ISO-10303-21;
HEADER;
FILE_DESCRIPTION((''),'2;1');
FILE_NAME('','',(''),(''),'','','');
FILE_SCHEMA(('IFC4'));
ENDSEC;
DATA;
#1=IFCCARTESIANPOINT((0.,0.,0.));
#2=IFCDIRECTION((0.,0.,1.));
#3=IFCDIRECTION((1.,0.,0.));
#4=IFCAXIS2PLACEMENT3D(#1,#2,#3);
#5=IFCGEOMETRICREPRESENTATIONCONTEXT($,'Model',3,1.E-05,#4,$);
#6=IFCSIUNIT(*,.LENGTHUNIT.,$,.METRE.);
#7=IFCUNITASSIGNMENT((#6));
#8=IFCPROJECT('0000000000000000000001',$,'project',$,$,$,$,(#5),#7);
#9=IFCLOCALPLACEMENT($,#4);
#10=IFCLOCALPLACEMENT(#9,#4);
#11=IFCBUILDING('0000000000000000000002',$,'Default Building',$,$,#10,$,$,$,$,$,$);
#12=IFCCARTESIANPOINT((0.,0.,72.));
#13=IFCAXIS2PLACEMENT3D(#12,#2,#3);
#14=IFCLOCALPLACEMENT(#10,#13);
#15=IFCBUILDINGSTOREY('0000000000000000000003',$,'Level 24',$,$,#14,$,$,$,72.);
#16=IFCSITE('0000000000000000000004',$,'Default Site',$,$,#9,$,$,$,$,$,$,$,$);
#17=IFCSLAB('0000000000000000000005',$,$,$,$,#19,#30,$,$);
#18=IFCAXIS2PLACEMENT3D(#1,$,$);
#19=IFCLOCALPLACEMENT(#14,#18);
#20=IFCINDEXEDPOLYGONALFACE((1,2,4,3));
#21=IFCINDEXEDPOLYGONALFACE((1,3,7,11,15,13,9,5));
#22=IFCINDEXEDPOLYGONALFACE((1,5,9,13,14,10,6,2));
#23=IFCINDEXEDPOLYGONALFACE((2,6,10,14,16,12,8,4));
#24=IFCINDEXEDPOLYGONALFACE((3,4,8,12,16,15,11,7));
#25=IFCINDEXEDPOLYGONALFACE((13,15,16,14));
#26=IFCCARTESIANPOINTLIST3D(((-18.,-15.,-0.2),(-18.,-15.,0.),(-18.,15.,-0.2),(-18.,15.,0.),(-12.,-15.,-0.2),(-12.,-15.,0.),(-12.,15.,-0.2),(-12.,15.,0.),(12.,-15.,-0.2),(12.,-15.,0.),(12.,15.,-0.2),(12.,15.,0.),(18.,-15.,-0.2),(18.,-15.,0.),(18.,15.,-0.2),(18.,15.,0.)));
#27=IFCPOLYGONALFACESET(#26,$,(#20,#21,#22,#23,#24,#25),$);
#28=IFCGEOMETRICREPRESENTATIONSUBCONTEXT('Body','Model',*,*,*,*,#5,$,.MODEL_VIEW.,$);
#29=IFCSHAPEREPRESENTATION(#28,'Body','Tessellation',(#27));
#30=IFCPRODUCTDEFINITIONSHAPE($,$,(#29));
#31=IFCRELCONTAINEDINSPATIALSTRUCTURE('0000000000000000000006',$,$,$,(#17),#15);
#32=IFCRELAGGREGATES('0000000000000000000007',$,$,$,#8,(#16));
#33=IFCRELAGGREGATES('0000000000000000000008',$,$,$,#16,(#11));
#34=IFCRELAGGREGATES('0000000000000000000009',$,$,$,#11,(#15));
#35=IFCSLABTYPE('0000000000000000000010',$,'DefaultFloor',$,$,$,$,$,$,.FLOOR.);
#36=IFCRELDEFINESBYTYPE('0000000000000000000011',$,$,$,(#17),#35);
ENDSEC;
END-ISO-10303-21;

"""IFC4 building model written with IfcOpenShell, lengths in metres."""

from ifc_helpers import new_model, si_unit, frame, origin_with_axes, place, context, subcontext, project, spatial, polyline, outline, extrude, type_object, element, save


model = new_model("IFC4")

# Units and contexts
model_context = context("Model", 3, precision=1e-05, world=origin_with_axes())
body_context = subcontext(model_context, "Body", "Model", "MODEL_VIEW")
ifc_project = project(units=[si_unit("LENGTHUNIT", "METRE")], contexts=[model_context])

# Site, building, storey
site_placement = place(None, origin_with_axes())
site = spatial("IfcSite", under=ifc_project, at=site_placement, Name="Default Site")
building_placement = place(site_placement, origin_with_axes())
building = spatial("IfcBuilding", under=site, at=building_placement, Name="Default Building")
storey_placement = place(building_placement, frame((0.0, 0.0, 72.0), z_axis=(0.0, 0.0, 1.0), x_axis=(1.0, 0.0, 0.0)))
storey = spatial("IfcBuildingStorey", under=building, at=storey_placement, Name="Level 24", Elevation=72.0)

# Slab
slab_type = type_object("IfcSlabType", Name="DefaultFloor", PredefinedType="FLOOR")
slab_placement = place(storey_placement, frame((0.0, 0.0, -72.0), z_axis=(0.0, 0.0, 1.0), x_axis=(1.0, 0.0, 0.0)))
element("IfcSlab", 1, at=slab_placement, inside=storey, type_object=slab_type, context=body_context, shape_type="SweptSolid", body=[
    extrude(outline(polyline([(-18.0, -15.0), (-18.0, 15.0), (-12.0, 15.0), (12.0, 15.0), (18.0, 15.0), (18.0, -15.0), (12.0, -15.0), (-12.0, -15.0), (-18.0, -15.0)])), frame((0.0, 0.0, 72.0), z_axis=(0.0, 0.0, 1.0), x_axis=(1.0, 0.0, 0.0)), (0.0, 0.0, -1.0), 0.2),
])

save(model, "model.ifc")
